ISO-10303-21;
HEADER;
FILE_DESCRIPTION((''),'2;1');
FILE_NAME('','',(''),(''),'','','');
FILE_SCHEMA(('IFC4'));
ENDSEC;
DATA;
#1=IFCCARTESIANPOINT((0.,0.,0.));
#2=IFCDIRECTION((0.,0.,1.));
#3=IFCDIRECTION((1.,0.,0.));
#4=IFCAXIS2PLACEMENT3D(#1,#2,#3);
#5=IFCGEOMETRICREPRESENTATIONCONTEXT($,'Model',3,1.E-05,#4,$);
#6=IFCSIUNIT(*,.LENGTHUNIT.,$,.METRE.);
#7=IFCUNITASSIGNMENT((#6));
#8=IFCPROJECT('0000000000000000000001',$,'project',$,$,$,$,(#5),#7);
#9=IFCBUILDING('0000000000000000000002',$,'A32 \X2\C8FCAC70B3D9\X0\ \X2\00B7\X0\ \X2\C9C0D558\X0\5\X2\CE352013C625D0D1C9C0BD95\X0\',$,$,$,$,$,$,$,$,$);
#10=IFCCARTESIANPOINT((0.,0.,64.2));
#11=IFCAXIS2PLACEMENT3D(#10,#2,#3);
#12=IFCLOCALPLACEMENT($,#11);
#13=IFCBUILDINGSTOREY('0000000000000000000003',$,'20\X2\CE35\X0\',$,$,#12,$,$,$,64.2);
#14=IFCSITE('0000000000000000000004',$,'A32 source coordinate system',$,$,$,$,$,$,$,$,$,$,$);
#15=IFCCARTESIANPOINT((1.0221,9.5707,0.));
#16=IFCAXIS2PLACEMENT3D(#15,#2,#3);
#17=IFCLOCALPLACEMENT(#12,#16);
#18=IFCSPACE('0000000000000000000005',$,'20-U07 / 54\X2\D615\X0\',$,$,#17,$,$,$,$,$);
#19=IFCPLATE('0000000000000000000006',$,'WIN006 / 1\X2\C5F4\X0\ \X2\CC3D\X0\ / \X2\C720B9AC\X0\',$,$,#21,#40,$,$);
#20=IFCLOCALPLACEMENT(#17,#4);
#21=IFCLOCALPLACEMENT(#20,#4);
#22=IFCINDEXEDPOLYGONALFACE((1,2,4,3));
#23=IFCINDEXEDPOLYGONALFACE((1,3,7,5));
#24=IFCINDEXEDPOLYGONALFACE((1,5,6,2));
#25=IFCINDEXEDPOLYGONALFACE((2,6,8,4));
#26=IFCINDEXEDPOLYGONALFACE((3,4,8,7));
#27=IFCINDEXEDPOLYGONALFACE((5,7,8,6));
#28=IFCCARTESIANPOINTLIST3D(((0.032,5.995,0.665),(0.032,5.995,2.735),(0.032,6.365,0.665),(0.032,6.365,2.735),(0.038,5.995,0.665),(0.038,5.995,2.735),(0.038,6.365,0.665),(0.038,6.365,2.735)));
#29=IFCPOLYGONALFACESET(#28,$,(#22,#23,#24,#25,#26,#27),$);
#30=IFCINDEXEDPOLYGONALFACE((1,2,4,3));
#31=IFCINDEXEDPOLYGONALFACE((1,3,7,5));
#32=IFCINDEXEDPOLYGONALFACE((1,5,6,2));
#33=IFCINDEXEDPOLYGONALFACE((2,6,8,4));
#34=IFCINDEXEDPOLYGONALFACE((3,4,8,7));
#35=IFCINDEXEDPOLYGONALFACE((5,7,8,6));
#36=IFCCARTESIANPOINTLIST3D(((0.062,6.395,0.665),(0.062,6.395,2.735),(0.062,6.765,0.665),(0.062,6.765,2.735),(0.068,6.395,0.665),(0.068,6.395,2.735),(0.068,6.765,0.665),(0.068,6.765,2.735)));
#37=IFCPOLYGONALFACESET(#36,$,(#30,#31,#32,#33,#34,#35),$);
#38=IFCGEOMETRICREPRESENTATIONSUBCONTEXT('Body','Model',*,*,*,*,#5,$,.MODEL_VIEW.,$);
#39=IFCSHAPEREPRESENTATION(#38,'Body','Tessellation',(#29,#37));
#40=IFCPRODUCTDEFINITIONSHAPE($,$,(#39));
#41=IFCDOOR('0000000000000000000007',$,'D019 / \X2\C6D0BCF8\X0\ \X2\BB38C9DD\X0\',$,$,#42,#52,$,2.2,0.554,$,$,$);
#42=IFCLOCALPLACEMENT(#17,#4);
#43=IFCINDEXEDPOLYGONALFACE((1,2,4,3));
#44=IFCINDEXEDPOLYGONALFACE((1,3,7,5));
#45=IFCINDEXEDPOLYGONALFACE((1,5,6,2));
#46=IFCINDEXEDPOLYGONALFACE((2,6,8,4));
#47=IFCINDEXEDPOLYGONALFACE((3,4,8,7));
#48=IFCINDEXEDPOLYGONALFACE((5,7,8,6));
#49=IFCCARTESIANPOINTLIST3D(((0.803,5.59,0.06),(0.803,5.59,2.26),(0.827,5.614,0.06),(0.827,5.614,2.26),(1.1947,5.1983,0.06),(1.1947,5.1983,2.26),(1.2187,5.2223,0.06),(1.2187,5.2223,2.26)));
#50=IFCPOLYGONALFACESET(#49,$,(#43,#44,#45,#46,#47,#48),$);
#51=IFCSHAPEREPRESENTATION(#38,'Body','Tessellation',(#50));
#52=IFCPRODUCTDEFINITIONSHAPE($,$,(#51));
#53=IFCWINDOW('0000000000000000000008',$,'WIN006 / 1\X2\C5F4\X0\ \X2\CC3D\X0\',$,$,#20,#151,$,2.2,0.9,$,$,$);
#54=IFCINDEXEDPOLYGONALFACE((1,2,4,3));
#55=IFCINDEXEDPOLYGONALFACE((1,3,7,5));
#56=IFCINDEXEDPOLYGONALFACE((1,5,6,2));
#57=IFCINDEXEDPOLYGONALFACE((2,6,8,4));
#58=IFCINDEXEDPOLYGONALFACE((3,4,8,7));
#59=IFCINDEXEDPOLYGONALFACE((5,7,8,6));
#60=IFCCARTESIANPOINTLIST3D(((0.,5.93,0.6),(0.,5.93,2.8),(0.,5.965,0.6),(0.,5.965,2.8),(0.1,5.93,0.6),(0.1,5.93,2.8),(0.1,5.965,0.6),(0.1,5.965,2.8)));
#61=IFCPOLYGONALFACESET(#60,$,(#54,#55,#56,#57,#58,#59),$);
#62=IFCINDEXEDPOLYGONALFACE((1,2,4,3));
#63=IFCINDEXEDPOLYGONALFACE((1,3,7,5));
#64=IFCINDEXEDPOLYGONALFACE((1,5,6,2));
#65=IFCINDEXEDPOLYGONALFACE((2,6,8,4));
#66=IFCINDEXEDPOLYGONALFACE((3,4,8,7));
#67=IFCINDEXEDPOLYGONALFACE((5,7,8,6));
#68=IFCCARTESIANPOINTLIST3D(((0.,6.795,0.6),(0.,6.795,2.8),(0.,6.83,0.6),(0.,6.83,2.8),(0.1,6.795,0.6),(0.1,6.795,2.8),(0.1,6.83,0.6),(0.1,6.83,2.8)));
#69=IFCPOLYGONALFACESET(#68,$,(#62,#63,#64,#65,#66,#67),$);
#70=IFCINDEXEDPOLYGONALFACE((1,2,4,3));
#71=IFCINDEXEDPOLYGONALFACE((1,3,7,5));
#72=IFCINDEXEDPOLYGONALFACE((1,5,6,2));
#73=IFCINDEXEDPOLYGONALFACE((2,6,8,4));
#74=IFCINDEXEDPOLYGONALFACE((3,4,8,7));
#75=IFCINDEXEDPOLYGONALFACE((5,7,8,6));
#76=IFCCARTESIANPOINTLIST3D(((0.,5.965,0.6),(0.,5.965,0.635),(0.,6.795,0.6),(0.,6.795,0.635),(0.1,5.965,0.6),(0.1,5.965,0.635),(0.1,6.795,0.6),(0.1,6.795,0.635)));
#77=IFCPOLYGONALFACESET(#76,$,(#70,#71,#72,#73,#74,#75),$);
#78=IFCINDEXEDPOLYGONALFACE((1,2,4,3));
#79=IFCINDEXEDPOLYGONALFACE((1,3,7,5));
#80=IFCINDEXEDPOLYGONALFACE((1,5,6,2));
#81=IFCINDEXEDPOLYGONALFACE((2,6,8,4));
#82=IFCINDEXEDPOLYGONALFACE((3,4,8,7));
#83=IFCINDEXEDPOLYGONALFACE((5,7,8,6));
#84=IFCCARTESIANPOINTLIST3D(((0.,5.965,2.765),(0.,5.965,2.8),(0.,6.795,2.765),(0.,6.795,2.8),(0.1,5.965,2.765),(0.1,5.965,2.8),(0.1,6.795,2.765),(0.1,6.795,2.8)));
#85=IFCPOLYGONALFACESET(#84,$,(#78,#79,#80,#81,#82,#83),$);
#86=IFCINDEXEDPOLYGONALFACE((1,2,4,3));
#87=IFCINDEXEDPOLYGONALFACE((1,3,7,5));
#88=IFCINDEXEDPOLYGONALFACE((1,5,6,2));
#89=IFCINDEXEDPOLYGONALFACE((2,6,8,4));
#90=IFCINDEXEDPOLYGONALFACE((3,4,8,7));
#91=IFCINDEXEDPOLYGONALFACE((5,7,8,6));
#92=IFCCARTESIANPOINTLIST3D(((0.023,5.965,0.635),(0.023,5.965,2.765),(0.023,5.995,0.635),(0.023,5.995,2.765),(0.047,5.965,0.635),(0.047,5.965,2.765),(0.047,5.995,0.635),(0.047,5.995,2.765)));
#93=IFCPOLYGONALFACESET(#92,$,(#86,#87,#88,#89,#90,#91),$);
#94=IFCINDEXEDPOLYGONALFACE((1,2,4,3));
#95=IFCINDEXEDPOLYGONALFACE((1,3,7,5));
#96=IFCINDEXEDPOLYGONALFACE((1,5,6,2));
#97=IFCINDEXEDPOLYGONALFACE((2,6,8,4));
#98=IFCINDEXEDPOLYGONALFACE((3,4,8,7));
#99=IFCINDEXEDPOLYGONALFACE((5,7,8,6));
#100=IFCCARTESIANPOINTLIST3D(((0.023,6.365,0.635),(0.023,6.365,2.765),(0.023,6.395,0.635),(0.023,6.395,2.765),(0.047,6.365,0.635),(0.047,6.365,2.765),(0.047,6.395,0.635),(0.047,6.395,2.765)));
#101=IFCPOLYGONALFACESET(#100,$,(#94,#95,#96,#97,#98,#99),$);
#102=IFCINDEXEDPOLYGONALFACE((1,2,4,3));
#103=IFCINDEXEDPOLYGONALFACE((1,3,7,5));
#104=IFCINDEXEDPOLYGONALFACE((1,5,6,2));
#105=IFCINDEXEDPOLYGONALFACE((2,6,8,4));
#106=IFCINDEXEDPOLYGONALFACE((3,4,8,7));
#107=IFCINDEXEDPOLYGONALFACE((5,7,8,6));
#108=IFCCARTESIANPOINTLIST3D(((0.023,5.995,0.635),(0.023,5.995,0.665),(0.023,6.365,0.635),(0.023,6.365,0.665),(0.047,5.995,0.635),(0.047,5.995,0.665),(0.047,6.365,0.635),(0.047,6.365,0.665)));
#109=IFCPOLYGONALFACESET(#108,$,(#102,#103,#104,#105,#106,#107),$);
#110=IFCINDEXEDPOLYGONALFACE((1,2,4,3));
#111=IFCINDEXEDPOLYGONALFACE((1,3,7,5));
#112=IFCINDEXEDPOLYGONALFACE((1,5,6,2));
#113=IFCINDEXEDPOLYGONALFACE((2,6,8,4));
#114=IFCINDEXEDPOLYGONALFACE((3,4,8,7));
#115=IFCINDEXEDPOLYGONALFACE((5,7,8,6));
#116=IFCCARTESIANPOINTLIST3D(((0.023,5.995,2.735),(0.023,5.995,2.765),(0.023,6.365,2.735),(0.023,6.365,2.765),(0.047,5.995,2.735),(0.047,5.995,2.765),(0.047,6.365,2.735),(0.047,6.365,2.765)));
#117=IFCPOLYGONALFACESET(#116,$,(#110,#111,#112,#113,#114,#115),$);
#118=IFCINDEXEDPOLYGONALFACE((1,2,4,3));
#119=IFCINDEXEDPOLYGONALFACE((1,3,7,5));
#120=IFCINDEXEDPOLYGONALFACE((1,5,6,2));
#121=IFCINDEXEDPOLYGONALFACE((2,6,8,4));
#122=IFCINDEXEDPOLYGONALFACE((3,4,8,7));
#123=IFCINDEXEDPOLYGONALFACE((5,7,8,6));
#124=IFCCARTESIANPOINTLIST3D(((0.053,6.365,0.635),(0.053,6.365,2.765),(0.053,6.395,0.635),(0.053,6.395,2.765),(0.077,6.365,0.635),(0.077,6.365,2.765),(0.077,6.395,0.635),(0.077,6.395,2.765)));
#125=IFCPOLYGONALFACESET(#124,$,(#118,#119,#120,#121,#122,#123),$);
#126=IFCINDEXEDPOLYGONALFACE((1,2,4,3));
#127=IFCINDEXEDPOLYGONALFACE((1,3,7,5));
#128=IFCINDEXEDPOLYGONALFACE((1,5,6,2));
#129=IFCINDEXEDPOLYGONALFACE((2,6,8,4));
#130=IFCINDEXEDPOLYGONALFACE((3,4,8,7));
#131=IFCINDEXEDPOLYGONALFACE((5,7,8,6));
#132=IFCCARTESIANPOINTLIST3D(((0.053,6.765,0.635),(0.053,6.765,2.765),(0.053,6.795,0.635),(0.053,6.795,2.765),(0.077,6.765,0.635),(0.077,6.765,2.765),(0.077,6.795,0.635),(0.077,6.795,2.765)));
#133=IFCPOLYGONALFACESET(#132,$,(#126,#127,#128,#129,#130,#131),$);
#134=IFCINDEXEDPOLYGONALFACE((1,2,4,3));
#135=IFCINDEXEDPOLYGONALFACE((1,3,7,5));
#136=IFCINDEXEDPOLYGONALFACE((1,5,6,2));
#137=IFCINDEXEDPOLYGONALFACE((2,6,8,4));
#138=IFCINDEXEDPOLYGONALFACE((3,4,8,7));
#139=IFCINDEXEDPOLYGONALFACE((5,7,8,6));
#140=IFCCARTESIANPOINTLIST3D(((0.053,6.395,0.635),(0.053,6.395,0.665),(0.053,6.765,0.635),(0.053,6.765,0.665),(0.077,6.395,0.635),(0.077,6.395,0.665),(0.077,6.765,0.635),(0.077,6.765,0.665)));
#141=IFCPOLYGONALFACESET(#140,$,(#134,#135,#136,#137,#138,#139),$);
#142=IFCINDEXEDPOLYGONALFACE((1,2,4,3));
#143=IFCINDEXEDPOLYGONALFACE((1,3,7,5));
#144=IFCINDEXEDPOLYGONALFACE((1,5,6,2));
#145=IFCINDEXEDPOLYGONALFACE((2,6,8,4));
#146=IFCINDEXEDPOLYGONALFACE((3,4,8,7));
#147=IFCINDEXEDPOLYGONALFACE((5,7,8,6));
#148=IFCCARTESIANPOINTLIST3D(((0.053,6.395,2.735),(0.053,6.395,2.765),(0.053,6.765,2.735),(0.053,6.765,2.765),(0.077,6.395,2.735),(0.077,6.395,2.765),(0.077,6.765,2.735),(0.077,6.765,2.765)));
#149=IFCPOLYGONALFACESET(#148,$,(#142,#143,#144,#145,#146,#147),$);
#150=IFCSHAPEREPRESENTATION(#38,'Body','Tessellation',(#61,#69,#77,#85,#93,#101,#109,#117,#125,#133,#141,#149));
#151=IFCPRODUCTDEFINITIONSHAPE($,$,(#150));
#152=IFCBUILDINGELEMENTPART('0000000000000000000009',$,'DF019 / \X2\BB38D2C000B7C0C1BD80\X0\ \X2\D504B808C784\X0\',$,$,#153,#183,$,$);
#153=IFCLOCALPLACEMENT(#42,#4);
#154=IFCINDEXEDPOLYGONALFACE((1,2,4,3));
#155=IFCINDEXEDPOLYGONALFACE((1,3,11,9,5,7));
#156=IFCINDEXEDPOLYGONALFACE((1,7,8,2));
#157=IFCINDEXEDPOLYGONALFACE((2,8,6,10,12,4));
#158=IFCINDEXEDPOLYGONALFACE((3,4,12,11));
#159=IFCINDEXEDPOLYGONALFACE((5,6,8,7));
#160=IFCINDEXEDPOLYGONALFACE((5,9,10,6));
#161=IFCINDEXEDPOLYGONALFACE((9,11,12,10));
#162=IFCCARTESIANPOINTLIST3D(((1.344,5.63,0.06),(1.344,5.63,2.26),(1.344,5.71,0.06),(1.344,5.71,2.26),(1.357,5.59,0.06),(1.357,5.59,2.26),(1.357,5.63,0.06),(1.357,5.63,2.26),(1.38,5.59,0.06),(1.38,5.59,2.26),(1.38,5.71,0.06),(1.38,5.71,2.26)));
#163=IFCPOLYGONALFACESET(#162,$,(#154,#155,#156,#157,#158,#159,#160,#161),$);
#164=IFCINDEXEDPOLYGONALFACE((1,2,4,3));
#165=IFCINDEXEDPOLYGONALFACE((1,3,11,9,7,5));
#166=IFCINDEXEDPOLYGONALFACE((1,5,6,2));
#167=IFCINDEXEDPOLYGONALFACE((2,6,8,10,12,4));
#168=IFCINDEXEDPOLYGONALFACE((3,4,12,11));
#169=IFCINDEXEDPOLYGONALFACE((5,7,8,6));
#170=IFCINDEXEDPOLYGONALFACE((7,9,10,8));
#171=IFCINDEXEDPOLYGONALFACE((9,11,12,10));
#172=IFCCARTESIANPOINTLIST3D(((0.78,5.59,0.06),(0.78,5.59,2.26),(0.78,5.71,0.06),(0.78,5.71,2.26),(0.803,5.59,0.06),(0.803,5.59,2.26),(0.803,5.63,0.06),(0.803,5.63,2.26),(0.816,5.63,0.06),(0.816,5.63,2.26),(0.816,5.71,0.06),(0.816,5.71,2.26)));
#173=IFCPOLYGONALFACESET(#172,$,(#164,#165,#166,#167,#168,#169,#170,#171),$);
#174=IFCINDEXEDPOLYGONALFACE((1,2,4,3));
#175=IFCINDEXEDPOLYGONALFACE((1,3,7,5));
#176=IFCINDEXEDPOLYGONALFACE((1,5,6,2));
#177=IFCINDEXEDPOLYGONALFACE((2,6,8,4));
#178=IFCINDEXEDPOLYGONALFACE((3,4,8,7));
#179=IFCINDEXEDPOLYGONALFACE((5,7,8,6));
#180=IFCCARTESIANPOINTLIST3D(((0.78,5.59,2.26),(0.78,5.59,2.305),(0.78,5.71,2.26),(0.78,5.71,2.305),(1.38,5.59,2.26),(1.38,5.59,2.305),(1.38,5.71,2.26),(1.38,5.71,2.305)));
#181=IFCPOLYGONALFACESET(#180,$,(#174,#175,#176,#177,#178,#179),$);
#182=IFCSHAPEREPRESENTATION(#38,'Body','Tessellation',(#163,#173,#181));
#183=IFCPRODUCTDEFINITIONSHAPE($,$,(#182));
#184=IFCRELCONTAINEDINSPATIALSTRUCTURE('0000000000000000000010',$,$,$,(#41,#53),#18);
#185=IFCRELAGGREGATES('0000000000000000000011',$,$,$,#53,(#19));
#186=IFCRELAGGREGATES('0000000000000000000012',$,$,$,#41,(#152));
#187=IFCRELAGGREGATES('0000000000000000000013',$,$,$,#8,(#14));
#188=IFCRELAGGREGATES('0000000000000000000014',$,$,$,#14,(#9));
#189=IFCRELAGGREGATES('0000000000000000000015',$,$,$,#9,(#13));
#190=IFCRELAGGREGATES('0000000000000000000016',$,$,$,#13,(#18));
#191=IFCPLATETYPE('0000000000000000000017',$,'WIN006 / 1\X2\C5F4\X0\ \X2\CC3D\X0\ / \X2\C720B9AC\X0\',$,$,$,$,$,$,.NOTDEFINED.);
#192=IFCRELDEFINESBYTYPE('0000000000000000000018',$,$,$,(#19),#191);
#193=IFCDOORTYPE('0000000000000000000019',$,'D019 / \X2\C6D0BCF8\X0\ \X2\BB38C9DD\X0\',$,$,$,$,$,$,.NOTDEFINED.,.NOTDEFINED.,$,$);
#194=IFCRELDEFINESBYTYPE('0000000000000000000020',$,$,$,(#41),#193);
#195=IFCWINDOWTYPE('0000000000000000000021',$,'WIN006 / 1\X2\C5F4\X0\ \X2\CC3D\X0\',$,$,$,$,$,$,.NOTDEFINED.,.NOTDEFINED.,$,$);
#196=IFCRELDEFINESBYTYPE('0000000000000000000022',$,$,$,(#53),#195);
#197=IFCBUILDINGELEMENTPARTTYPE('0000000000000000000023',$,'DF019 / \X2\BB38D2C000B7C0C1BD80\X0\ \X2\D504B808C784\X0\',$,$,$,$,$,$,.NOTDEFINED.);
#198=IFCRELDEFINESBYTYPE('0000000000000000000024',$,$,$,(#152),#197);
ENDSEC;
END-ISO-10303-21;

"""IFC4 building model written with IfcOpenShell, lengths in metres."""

from ifc_helpers import new_model, si_unit, frame, origin, origin_with_axes, place, context, subcontext, project, spatial, polyline, outline, extrude, source, transform, mapped, type_object, type_shapes, element, aggregate, save


model = new_model("IFC4")

# Units and contexts
model_context = context("Model", 3, precision=1e-05, world=origin_with_axes())
body_context = subcontext(model_context, "Body", "Model", "MODEL_VIEW")
ifc_project = project(units=[si_unit("LENGTHUNIT", "METRE")], contexts=[model_context])

# Plate
storey_placement = place(None, frame((0.0, 0.0, 64.2), z_axis=(0.0, 0.0, 1.0), x_axis=(1.0, 0.0, 0.0)))
space_placement = place(storey_placement, frame((1.0221, 9.5707, 0.0), z_axis=(0.0, 0.0, 1.0), x_axis=(1.0, 0.0, 0.0)))
plate_type_1 = type_object("IfcPlateType", Name="WIN006 / 1열 창 / 유리", PredefinedType="NOTDEFINED")
shared_shape_1 = source(origin(), body_context, "Body", "SweptSolid", [
    extrude(outline(polyline([(0.032, 5.995), (0.032, 6.365), (0.038, 6.365), (0.038, 5.995), (0.032, 5.995)])), frame((0.0, 0.0, 0.665)), (0.0, 0.0, 1.0), 2.07),
    extrude(outline(polyline([(0.062, 6.395), (0.062, 6.765), (0.068, 6.765), (0.068, 6.395), (0.062, 6.395)])), frame((0.0, 0.0, 0.665)), (0.0, 0.0, 1.0), 2.07),
])
type_shapes(plate_type_1, [shared_shape_1])
window_1_placement = place(space_placement, origin_with_axes())
plate_1_placement = place(window_1_placement, origin_with_axes())
plate_1 = element("IfcPlate", 1, at=plate_1_placement, type_object=plate_type_1, Name="WIN006 / 1열 창 / 유리", context=body_context, shape_type="MappedRepresentation", body=[
    mapped(shared_shape_1, transform((0.0, 0.0, 0.0), scale=1.0)),
])

# Site, building, storey, space
site = spatial("IfcSite", under=ifc_project, Name="A32 source coordinate system")
building = spatial("IfcBuilding", under=site, Name="A32 주거동 · 지하5층–옥탑지붕")
storey = spatial("IfcBuildingStorey", under=building, at=storey_placement, Name="20층", Elevation=64.2)
space = spatial("IfcSpace", under=storey, at=space_placement, Name="20-U07 / 54형")

# Door
door_type_1 = type_object("IfcDoorType", Name="D019 / 원본 문짝", OperationType="NOTDEFINED", PredefinedType="NOTDEFINED")
shared_shape_2 = source(origin(), body_context, "Body", "SweptSolid", [
    extrude(outline(polyline([(1.2187, 5.2223), (1.1947, 5.1983), (0.803, 5.59), (0.827, 5.614), (1.2187, 5.2223)])), frame((0.0, 0.0, 0.06)), (0.0, 0.0, 1.0), 2.2),
])
type_shapes(door_type_1, [shared_shape_2])
door_1_placement = place(space_placement, origin_with_axes())
door_1 = element("IfcDoor", 2, at=door_1_placement, inside=space, type_object=door_type_1, Name="D019 / 원본 문짝", OverallHeight=2.2, OverallWidth=0.554, context=body_context, shape_type="MappedRepresentation", body=[
    mapped(shared_shape_2, transform((0.0, 0.0, 0.0), scale=1.0)),
])

# Window
window_type_1 = type_object("IfcWindowType", Name="WIN006 / 1열 창", PartitioningType="NOTDEFINED", PredefinedType="NOTDEFINED")
shared_shape_3 = source(origin(), body_context, "Body", "SweptSolid", [
    extrude(outline(polyline([(0.0, 5.93), (0.0, 5.965), (0.1, 5.965), (0.1, 5.93), (0.0, 5.93)])), frame((0.0, 0.0, 0.6)), (0.0, 0.0, 1.0), 2.2),
    extrude(outline(polyline([(0.0, 6.795), (0.0, 6.83), (0.1, 6.83), (0.1, 6.795), (0.0, 6.795)])), frame((0.0, 0.0, 0.6)), (0.0, 0.0, 1.0), 2.2),
    extrude(outline(polyline([(0.0, 5.965), (0.0, 6.795), (0.1, 6.795), (0.1, 5.965), (0.0, 5.965)])), frame((0.0, 0.0, 0.6)), (0.0, 0.0, 1.0), 0.035),
    extrude(outline(polyline([(0.0, 5.965), (0.0, 6.795), (0.1, 6.795), (0.1, 5.965), (0.0, 5.965)])), frame((0.0, 0.0, 2.765)), (0.0, 0.0, 1.0), 0.035),
    extrude(outline(polyline([(0.023, 5.965), (0.023, 5.995), (0.047, 5.995), (0.047, 5.965), (0.023, 5.965)])), frame((0.0, 0.0, 0.635)), (0.0, 0.0, 1.0), 2.13),
    extrude(outline(polyline([(0.023, 6.365), (0.023, 6.395), (0.047, 6.395), (0.047, 6.365), (0.023, 6.365)])), frame((0.0, 0.0, 0.635)), (0.0, 0.0, 1.0), 2.13),
    extrude(outline(polyline([(0.023, 5.995), (0.023, 6.365), (0.047, 6.365), (0.047, 5.995), (0.023, 5.995)])), frame((0.0, 0.0, 0.635)), (0.0, 0.0, 1.0), 0.03),
    extrude(outline(polyline([(0.023, 5.995), (0.023, 6.365), (0.047, 6.365), (0.047, 5.995), (0.023, 5.995)])), frame((0.0, 0.0, 2.735)), (0.0, 0.0, 1.0), 0.03),
    extrude(outline(polyline([(0.053, 6.365), (0.053, 6.395), (0.077, 6.395), (0.077, 6.365), (0.053, 6.365)])), frame((0.0, 0.0, 0.635)), (0.0, 0.0, 1.0), 2.13),
    extrude(outline(polyline([(0.053, 6.765), (0.053, 6.795), (0.077, 6.795), (0.077, 6.765), (0.053, 6.765)])), frame((0.0, 0.0, 0.635)), (0.0, 0.0, 1.0), 2.13),
    extrude(outline(polyline([(0.053, 6.395), (0.053, 6.765), (0.077, 6.765), (0.077, 6.395), (0.053, 6.395)])), frame((0.0, 0.0, 0.635)), (0.0, 0.0, 1.0), 0.03),
    extrude(outline(polyline([(0.053, 6.395), (0.053, 6.765), (0.077, 6.765), (0.077, 6.395), (0.053, 6.395)])), frame((0.0, 0.0, 2.735)), (0.0, 0.0, 1.0), 0.03),
])
type_shapes(window_type_1, [shared_shape_3])
window_1 = element("IfcWindow", 3, at=window_1_placement, inside=space, type_object=window_type_1, Name="WIN006 / 1열 창", OverallHeight=2.2, OverallWidth=0.9, context=body_context, shape_type="MappedRepresentation", body=[
    mapped(shared_shape_3, transform((0.0, 0.0, 0.0), scale=1.0)),
])
aggregate(window_1, [plate_1])

# Building element part
building_element_part_type_1 = type_object("IfcBuildingElementPartType", Name="DF019 / 문틀·상부 프레임", PredefinedType="NOTDEFINED")
shared_shape_4 = source(origin(), body_context, "Body", "SweptSolid", [
    extrude(outline(polyline([(1.38, 5.59), (1.357, 5.59), (1.357, 5.63), (1.344, 5.63), (1.344, 5.71), (1.38, 5.71), (1.38, 5.59)])), frame((0.0, 0.0, 0.06)), (0.0, 0.0, 1.0), 2.2),
    extrude(outline(polyline([(0.816, 5.71), (0.816, 5.63), (0.803, 5.63), (0.803, 5.59), (0.78, 5.59), (0.78, 5.71), (0.816, 5.71)])), frame((0.0, 0.0, 0.06)), (0.0, 0.0, 1.0), 2.2),
    extrude(outline(polyline([(0.78, 5.59), (0.78, 5.71), (1.38, 5.71), (1.38, 5.59), (0.78, 5.59)])), frame((0.0, 0.0, 2.26)), (0.0, 0.0, 1.0), 0.045),
])
type_shapes(building_element_part_type_1, [shared_shape_4])
building_element_part_1_placement = place(door_1_placement, origin_with_axes())
building_element_part_1 = element("IfcBuildingElementPart", 4, at=building_element_part_1_placement, type_object=building_element_part_type_1, Name="DF019 / 문틀·상부 프레임", context=body_context, shape_type="MappedRepresentation", body=[
    mapped(shared_shape_4, transform((0.0, 0.0, 0.0), scale=1.0)),
])
aggregate(door_1, [building_element_part_1])

save(model, "model.ifc")
